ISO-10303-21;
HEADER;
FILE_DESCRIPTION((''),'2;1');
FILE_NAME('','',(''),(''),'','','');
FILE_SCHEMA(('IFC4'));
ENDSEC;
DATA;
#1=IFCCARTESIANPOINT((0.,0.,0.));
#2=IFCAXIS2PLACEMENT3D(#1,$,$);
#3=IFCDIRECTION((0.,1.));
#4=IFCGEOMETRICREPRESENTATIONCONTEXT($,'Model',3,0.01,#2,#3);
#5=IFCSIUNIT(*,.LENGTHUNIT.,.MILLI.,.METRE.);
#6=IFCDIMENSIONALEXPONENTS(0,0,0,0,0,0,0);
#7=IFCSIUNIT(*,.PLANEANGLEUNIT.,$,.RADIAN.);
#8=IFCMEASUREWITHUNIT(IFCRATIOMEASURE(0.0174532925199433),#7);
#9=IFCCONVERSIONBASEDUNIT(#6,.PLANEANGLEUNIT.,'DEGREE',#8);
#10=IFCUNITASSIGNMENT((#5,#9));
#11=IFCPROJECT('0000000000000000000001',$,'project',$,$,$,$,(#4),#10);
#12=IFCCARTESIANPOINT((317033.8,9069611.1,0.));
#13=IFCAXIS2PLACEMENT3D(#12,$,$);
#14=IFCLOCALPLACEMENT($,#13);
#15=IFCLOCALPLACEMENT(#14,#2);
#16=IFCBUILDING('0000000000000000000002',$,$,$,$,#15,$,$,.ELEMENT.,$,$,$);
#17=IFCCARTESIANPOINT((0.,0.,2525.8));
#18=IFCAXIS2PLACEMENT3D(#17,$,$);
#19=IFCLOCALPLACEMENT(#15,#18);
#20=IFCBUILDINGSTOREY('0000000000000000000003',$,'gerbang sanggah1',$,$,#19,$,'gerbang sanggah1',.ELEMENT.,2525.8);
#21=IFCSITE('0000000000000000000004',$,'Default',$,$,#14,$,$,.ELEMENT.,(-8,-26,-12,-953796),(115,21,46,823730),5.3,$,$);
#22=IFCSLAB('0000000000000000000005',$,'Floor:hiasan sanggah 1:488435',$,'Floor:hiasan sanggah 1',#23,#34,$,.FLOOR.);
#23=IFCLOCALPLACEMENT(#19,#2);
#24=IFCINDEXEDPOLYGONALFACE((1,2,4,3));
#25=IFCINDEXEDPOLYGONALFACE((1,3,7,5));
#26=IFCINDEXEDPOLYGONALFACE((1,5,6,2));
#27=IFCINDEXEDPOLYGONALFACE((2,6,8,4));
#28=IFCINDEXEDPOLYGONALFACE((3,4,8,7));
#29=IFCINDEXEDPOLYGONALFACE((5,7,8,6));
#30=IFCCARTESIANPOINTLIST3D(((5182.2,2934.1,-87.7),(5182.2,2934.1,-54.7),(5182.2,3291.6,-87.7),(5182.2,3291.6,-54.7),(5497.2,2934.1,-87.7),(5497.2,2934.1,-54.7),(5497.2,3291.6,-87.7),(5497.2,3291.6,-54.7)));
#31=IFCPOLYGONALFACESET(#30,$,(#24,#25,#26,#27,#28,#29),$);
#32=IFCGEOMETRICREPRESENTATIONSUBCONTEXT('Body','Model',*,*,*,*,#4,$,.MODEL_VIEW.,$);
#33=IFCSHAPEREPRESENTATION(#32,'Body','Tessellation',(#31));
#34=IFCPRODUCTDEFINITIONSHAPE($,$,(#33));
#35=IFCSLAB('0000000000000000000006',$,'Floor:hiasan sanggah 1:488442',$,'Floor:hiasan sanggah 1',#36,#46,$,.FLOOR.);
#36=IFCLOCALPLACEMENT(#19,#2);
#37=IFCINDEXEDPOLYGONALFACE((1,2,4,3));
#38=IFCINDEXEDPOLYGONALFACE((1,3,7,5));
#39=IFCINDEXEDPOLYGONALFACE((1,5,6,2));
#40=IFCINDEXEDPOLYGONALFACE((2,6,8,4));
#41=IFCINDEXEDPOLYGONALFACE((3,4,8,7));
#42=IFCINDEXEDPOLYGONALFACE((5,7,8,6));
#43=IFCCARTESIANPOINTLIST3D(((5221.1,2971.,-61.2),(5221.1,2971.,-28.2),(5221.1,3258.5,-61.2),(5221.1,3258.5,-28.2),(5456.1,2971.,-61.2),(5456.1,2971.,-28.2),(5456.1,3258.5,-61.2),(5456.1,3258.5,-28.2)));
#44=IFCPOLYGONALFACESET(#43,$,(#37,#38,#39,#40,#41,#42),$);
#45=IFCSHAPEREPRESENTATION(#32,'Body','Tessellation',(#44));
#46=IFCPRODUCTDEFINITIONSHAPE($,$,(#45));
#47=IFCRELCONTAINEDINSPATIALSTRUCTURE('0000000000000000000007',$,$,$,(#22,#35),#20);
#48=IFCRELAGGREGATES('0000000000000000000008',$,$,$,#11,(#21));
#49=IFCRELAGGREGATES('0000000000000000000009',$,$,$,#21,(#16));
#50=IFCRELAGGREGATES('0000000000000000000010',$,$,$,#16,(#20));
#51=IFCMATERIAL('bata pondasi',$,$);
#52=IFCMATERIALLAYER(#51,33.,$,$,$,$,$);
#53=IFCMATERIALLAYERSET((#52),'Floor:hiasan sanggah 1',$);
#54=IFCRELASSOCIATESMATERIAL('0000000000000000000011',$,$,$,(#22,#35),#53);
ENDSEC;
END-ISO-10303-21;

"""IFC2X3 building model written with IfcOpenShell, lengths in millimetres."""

from ifc_helpers import new_model, entity, si_unit, converted_unit, direction, frame, frame_2d, origin, place, context, subcontext, project, spatial, rectangle, extrude, material, layer, layer_set, layer_usage, element, save


model = new_model("IFC2X3")

# Units and contexts
model_context = context("Model", 3, precision=0.01, world=origin(), true_north=direction((0.0, 1.0)))
body_context = subcontext(model_context, "Body", "Model", "MODEL_VIEW")
ifc_project = project(units=[si_unit("LENGTHUNIT", "METRE", prefix="MILLI"), converted_unit("PLANEANGLEUNIT", "DEGREE", entity("IfcRatioMeasure", 0.0174532925199433), si_unit("PLANEANGLEUNIT", "RADIAN"), dimensions=[0, 0, 0, 0, 0, 0, 0])], contexts=[model_context])

# Site, building, storey
site_placement = place(None, frame((317033.8, 9069611.1, 0.0)))
site = spatial("IfcSite", under=ifc_project, at=site_placement, Name="Default", CompositionType="ELEMENT", RefLatitude=(-8, -26, -12, -953796), RefLongitude=(115, 21, 46, 823730), RefElevation=5.3)
building_placement = place(site_placement, origin())
building = spatial("IfcBuilding", under=site, at=building_placement, CompositionType="ELEMENT")
storey_placement = place(building_placement, frame((0.0, 0.0, 2525.8)))
storey = spatial("IfcBuildingStorey", under=building, at=storey_placement, Name="gerbang sanggah1", LongName="gerbang sanggah1", CompositionType="ELEMENT", Elevation=2525.8)

# Slabs
ifc_material = material(Name="bata pondasi")
ifc_layer = layer(ifc_material, 33.0)
ifc_layer_set = layer_set([ifc_layer], Name="Floor:hiasan sanggah 1")
ifc_layer_usage_1 = layer_usage(ifc_layer_set, "AXIS3", "POSITIVE", 0.0)
slab_1_placement = place(storey_placement, origin())
element("IfcSlab", 1, at=slab_1_placement, inside=storey, material=ifc_layer_usage_1, Name="Floor:hiasan sanggah 1:488435", ObjectType="Floor:hiasan sanggah 1", PredefinedType="FLOOR", context=body_context, shape_type="SweptSolid", body=[
    extrude(rectangle(XDim=357.5, YDim=315.0, at=frame_2d((0.0, 0.0), x_axis=(1.0, 0.0))), frame((5339.7, 3112.8, -54.7), z_axis=(0.0, 0.0, -1.0), x_axis=(0.0, 1.0, 0.0)), (0.0, 0.0, 1.0), 33.0),
])
ifc_layer_usage_2 = layer_usage(ifc_layer_set, "AXIS3", "POSITIVE", 0.0)
slab_2_placement = place(storey_placement, origin())
element("IfcSlab", 2, at=slab_2_placement, inside=storey, material=ifc_layer_usage_2, Name="Floor:hiasan sanggah 1:488442", ObjectType="Floor:hiasan sanggah 1", PredefinedType="FLOOR", context=body_context, shape_type="SweptSolid", body=[
    extrude(rectangle(XDim=287.5, YDim=235.0, at=frame_2d((0.0, 0.0), x_axis=(1.0, 0.0))), frame((5338.6, 3114.8, -28.2), z_axis=(0.0, 0.0, -1.0), x_axis=(0.0, 1.0, 0.0)), (0.0, 0.0, 1.0), 33.0),
])

save(model, "model.ifc")
